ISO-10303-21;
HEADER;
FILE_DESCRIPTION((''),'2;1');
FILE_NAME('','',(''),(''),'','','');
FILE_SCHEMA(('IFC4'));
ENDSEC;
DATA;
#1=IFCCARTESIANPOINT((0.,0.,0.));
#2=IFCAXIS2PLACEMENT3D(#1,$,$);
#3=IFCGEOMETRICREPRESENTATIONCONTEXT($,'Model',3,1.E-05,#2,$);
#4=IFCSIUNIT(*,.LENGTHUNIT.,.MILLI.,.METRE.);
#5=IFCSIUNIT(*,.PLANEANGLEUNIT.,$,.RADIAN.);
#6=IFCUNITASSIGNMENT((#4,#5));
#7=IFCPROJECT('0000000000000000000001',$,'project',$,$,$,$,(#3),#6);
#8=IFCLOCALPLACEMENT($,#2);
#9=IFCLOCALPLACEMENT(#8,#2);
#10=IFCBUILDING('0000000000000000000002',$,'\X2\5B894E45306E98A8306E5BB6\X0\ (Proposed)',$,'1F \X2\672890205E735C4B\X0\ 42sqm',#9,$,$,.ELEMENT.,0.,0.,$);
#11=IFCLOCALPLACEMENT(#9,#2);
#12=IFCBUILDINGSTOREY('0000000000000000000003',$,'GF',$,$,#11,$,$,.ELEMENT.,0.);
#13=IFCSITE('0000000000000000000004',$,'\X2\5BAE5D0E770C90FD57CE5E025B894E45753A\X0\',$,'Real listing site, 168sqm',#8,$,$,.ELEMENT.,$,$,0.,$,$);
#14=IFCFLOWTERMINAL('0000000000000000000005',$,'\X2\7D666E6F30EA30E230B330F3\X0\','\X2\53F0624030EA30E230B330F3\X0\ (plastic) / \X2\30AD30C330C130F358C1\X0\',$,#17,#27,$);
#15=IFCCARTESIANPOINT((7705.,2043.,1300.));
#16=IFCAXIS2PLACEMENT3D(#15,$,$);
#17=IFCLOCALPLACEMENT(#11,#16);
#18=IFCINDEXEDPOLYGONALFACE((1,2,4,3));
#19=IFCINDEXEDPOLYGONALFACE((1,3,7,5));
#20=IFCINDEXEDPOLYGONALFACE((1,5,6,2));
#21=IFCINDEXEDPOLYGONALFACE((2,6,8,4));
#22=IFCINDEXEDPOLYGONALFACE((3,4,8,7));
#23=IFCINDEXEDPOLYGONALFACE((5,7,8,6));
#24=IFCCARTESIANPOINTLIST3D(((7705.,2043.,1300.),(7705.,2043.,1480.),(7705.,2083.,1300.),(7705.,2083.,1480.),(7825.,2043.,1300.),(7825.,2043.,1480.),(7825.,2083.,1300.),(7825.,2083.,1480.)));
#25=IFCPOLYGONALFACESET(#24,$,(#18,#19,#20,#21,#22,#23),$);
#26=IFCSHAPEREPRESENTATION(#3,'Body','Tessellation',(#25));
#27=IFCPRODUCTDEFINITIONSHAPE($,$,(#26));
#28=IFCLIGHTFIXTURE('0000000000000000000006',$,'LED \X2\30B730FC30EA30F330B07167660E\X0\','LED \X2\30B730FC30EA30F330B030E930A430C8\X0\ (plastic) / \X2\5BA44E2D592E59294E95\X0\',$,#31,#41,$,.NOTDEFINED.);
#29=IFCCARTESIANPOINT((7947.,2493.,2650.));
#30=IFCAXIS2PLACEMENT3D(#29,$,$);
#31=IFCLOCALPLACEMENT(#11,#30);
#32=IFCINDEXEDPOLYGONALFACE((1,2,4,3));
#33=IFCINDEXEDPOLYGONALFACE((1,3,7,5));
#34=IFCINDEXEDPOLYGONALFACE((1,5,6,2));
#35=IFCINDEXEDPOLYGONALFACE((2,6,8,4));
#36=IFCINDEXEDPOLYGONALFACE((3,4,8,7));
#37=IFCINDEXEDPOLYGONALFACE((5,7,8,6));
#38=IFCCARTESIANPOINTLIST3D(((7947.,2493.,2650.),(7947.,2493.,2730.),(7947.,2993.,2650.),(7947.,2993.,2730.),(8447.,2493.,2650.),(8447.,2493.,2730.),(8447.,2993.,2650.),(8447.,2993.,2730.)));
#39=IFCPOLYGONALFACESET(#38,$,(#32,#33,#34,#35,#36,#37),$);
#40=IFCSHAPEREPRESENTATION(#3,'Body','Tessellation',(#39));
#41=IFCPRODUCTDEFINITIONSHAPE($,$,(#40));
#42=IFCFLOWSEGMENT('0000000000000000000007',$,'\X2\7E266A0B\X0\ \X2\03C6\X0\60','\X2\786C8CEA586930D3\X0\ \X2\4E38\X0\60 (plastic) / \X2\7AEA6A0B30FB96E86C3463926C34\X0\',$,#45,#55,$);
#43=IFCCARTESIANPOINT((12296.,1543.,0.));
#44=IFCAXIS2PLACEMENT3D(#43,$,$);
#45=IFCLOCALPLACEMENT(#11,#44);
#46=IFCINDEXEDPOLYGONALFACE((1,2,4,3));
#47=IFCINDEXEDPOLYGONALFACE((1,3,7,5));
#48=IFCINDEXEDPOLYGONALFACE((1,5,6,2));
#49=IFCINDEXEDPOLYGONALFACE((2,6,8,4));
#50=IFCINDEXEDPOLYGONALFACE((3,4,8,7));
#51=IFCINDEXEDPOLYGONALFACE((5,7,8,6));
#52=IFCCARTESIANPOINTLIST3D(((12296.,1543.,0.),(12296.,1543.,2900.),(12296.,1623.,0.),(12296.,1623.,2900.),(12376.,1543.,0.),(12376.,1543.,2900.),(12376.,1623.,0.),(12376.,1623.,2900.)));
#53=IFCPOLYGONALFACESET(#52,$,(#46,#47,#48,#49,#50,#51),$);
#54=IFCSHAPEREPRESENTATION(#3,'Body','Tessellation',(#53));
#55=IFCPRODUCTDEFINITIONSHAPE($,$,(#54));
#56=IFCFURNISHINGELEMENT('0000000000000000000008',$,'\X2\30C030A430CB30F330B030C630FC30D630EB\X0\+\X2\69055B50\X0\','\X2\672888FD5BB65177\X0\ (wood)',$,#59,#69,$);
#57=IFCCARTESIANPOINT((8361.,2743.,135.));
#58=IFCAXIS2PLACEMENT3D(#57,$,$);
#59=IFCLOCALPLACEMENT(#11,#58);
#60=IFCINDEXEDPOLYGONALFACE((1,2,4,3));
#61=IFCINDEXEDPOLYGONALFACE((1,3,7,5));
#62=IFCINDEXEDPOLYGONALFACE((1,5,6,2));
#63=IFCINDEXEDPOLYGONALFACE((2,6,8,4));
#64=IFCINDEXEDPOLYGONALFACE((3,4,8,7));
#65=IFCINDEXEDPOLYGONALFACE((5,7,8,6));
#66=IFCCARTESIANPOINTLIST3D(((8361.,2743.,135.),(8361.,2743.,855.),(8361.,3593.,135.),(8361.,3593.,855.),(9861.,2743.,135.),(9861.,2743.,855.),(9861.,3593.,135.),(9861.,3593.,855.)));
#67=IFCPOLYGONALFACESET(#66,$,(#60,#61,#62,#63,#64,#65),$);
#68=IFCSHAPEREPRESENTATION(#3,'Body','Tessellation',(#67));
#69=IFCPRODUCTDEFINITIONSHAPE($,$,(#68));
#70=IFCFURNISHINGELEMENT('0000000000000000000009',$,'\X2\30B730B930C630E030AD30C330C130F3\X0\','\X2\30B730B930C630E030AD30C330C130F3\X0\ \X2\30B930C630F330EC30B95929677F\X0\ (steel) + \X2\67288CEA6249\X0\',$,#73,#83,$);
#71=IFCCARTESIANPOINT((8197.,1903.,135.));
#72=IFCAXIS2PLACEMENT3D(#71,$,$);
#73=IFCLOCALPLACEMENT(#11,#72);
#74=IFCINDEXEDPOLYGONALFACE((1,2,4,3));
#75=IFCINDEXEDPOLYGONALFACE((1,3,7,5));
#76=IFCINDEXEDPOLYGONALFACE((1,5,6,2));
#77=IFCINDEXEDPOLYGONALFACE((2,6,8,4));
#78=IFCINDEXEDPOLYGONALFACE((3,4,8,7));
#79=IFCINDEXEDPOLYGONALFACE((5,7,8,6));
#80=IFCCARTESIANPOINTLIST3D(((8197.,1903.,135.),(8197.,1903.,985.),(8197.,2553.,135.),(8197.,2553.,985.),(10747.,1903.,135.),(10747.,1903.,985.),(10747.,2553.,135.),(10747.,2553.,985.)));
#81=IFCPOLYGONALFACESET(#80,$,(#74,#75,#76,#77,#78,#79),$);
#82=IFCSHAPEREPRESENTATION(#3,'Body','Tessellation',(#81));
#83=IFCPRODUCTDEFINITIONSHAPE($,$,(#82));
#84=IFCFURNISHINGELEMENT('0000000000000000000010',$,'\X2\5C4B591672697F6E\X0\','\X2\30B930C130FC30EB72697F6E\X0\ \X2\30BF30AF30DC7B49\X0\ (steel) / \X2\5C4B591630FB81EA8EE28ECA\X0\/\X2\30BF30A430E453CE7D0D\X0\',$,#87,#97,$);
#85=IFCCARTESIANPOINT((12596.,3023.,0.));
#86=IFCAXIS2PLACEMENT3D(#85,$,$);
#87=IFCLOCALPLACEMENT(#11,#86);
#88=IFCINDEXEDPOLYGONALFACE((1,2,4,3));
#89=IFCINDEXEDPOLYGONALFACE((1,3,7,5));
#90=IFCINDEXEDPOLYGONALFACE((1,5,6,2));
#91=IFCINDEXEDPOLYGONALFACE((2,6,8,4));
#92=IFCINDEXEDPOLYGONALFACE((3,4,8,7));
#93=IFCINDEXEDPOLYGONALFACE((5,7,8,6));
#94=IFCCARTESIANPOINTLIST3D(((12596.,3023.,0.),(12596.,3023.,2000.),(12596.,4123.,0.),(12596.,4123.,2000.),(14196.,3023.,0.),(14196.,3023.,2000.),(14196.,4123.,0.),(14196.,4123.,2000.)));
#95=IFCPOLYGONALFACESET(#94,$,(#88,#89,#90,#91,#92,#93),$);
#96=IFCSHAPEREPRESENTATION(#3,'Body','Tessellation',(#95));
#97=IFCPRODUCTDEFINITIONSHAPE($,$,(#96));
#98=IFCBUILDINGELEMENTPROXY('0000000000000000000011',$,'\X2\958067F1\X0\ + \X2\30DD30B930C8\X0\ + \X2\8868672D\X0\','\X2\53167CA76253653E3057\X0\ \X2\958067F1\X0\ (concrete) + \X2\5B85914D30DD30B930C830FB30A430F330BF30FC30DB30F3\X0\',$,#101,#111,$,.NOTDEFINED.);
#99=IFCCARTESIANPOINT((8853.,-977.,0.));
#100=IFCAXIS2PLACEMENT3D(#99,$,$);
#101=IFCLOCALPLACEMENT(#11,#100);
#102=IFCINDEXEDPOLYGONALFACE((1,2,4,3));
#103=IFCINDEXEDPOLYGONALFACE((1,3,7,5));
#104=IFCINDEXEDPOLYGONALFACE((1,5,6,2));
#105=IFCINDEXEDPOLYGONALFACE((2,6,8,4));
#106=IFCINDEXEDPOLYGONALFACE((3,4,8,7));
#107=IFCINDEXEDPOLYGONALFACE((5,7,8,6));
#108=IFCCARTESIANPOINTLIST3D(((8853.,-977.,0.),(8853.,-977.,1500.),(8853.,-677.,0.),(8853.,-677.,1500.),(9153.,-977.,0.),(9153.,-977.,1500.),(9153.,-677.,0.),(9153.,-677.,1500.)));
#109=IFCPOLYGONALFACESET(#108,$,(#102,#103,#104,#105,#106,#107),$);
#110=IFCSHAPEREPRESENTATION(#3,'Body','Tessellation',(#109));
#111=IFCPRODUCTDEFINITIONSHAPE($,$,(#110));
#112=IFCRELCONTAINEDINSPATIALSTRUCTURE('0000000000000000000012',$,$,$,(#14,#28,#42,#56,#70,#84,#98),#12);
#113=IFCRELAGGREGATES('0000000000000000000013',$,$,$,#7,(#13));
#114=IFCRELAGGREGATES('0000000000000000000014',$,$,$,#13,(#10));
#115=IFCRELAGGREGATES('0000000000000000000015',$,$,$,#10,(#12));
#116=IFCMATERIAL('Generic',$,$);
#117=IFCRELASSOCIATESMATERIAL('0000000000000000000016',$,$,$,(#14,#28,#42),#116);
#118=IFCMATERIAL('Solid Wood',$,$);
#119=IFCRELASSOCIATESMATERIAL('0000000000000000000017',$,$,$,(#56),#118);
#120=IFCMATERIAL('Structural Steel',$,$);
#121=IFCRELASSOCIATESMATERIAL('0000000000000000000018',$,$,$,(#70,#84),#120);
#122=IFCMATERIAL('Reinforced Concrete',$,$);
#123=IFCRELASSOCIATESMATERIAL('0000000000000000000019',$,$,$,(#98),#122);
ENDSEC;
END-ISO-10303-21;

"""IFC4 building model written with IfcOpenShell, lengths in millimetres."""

from ifc_helpers import new_model, si_unit, frame, frame_2d, origin, place, context, project, spatial, rectangle, extrude, material, element, save


model = new_model("IFC4")

# Units and contexts
model_context = context("Model", 3, precision=1e-05, world=origin())
ifc_project = project(units=[si_unit("LENGTHUNIT", "METRE", prefix="MILLI"), si_unit("PLANEANGLEUNIT", "RADIAN")], contexts=[model_context])

# Site, building, storey
site_placement = place(None, origin())
site = spatial("IfcSite", under=ifc_project, at=site_placement, Name="宮崎県都城市安久町", ObjectType="Real listing site, 168sqm", CompositionType="ELEMENT", RefElevation=0.0)
building_placement = place(site_placement, origin())
building = spatial("IfcBuilding", under=site, at=building_placement, Name="安久の風の家 (Proposed)", ObjectType="1F 木造平屋 42sqm", CompositionType="ELEMENT", ElevationOfRefHeight=0.0, ElevationOfTerrain=0.0)
storey_placement = place(building_placement, origin())
storey = spatial("IfcBuildingStorey", under=building, at=storey_placement, Name="GF", CompositionType="ELEMENT", Elevation=0.0)

# Shared definitions
ifc_material_1 = material(Name="Solid Wood")

# Shared definitions
ifc_material_2 = material(Name="Structural Steel")

# Shared definitions
ifc_material_3 = material(Name="Reinforced Concrete")

# Flow terminal
ifc_material_4 = material(Name="Generic")
flow_terminal_1_placement = place(storey_placement, frame((7705.0, 2043.0, 1300.0)))
element("IfcFlowTerminal", 1, at=flow_terminal_1_placement, inside=storey, material=ifc_material_4, Name="給湯リモコン", Description="台所リモコン (plastic) / キッチン壁", context=model_context, shape_type="SweptSolid", body=[
    extrude(rectangle(XDim=120.0, YDim=40.0, at=frame_2d((60.0, 20.0))), frame((7705.0, 2043.0, 1300.0)), (0.0, 0.0, 1.0), 180.0),
])

# Light fixture
light_fixture_placement = place(storey_placement, frame((7947.0, 2493.0, 2650.0)))
element("IfcLightFixture", 2, at=light_fixture_placement, inside=storey, material=ifc_material_4, Name="LED シーリング照明", Description="LED シーリングライト (plastic) / 室中央天井", PredefinedType="NOTDEFINED", context=model_context, shape_type="SweptSolid", body=[
    extrude(rectangle(XDim=500.0, YDim=500.0, at=frame_2d((250.0, 250.0))), frame((7947.0, 2493.0, 2650.0)), (0.0, 0.0, 1.0), 80.0),
])

# Flow segment
flow_segment_placement = place(storey_placement, frame((12296.0, 1543.0, 0.0)))
element("IfcFlowSegment", 3, at=flow_segment_placement, inside=storey, material=ifc_material_4, Name="縦樋 φ60", Description="硬質塩ビ 丸60 (plastic) / 竪樋・雨水排水", context=model_context, shape_type="SweptSolid", body=[
    extrude(rectangle(XDim=80.0, YDim=80.0, at=frame_2d((40.0, 40.0))), frame((12296.0, 1543.0, 0.0)), (0.0, 0.0, 1.0), 2900.0),
])

# Furnishing elements
furnishing_1_placement = place(storey_placement, frame((8361.0, 2743.0, 135.0)))
element("IfcFurnishingElement", 4, at=furnishing_1_placement, inside=storey, material=ifc_material_1, Name="ダイニングテーブル+椅子", Description="木製家具 (wood)", context=model_context, shape_type="SweptSolid", body=[
    extrude(rectangle(XDim=1500.0, YDim=850.0, at=frame_2d((750.0, 425.0))), frame((8361.0, 2743.0, 135.0)), (0.0, 0.0, 1.0), 720.0),
])
furnishing_2_placement = place(storey_placement, frame((8197.0, 1903.0, 135.0)))
element("IfcFurnishingElement", 5, at=furnishing_2_placement, inside=storey, material=ifc_material_2, Name="システムキッチン", Description="システムキッチン ステンレス天板 (steel) + 木質扉", context=model_context, shape_type="SweptSolid", body=[
    extrude(rectangle(XDim=2550.0, YDim=650.0, at=frame_2d((1275.0, 325.0))), frame((8197.0, 1903.0, 135.0)), (0.0, 0.0, 1.0), 850.0),
])
furnishing_3_placement = place(storey_placement, frame((12596.0, 3023.0, 0.0)))
element("IfcFurnishingElement", 6, at=furnishing_3_placement, inside=storey, material=ifc_material_2, Name="屋外物置", Description="スチール物置 タクボ等 (steel) / 屋外・自転車/タイヤ収納", context=model_context, shape_type="SweptSolid", body=[
    extrude(rectangle(XDim=1600.0, YDim=1100.0, at=frame_2d((800.0, 550.0))), frame((12596.0, 3023.0, 0.0)), (0.0, 0.0, 1.0), 2000.0),
])

# Building element proxy
proxy_placement = place(storey_placement, frame((8853.0, -977.0, 0.0)))
element("IfcBuildingElementProxy", 7, at=proxy_placement, inside=storey, material=ifc_material_3, Name="門柱 + ポスト + 表札", Description="化粧打放し 門柱 (concrete) + 宅配ポスト・インターホン", PredefinedType="NOTDEFINED", context=model_context, shape_type="SweptSolid", body=[
    extrude(rectangle(XDim=300.0, YDim=300.0, at=frame_2d((150.0, 150.0))), frame((8853.0, -977.0, 0.0)), (0.0, 0.0, 1.0), 1500.0),
])

save(model, "model.ifc")
